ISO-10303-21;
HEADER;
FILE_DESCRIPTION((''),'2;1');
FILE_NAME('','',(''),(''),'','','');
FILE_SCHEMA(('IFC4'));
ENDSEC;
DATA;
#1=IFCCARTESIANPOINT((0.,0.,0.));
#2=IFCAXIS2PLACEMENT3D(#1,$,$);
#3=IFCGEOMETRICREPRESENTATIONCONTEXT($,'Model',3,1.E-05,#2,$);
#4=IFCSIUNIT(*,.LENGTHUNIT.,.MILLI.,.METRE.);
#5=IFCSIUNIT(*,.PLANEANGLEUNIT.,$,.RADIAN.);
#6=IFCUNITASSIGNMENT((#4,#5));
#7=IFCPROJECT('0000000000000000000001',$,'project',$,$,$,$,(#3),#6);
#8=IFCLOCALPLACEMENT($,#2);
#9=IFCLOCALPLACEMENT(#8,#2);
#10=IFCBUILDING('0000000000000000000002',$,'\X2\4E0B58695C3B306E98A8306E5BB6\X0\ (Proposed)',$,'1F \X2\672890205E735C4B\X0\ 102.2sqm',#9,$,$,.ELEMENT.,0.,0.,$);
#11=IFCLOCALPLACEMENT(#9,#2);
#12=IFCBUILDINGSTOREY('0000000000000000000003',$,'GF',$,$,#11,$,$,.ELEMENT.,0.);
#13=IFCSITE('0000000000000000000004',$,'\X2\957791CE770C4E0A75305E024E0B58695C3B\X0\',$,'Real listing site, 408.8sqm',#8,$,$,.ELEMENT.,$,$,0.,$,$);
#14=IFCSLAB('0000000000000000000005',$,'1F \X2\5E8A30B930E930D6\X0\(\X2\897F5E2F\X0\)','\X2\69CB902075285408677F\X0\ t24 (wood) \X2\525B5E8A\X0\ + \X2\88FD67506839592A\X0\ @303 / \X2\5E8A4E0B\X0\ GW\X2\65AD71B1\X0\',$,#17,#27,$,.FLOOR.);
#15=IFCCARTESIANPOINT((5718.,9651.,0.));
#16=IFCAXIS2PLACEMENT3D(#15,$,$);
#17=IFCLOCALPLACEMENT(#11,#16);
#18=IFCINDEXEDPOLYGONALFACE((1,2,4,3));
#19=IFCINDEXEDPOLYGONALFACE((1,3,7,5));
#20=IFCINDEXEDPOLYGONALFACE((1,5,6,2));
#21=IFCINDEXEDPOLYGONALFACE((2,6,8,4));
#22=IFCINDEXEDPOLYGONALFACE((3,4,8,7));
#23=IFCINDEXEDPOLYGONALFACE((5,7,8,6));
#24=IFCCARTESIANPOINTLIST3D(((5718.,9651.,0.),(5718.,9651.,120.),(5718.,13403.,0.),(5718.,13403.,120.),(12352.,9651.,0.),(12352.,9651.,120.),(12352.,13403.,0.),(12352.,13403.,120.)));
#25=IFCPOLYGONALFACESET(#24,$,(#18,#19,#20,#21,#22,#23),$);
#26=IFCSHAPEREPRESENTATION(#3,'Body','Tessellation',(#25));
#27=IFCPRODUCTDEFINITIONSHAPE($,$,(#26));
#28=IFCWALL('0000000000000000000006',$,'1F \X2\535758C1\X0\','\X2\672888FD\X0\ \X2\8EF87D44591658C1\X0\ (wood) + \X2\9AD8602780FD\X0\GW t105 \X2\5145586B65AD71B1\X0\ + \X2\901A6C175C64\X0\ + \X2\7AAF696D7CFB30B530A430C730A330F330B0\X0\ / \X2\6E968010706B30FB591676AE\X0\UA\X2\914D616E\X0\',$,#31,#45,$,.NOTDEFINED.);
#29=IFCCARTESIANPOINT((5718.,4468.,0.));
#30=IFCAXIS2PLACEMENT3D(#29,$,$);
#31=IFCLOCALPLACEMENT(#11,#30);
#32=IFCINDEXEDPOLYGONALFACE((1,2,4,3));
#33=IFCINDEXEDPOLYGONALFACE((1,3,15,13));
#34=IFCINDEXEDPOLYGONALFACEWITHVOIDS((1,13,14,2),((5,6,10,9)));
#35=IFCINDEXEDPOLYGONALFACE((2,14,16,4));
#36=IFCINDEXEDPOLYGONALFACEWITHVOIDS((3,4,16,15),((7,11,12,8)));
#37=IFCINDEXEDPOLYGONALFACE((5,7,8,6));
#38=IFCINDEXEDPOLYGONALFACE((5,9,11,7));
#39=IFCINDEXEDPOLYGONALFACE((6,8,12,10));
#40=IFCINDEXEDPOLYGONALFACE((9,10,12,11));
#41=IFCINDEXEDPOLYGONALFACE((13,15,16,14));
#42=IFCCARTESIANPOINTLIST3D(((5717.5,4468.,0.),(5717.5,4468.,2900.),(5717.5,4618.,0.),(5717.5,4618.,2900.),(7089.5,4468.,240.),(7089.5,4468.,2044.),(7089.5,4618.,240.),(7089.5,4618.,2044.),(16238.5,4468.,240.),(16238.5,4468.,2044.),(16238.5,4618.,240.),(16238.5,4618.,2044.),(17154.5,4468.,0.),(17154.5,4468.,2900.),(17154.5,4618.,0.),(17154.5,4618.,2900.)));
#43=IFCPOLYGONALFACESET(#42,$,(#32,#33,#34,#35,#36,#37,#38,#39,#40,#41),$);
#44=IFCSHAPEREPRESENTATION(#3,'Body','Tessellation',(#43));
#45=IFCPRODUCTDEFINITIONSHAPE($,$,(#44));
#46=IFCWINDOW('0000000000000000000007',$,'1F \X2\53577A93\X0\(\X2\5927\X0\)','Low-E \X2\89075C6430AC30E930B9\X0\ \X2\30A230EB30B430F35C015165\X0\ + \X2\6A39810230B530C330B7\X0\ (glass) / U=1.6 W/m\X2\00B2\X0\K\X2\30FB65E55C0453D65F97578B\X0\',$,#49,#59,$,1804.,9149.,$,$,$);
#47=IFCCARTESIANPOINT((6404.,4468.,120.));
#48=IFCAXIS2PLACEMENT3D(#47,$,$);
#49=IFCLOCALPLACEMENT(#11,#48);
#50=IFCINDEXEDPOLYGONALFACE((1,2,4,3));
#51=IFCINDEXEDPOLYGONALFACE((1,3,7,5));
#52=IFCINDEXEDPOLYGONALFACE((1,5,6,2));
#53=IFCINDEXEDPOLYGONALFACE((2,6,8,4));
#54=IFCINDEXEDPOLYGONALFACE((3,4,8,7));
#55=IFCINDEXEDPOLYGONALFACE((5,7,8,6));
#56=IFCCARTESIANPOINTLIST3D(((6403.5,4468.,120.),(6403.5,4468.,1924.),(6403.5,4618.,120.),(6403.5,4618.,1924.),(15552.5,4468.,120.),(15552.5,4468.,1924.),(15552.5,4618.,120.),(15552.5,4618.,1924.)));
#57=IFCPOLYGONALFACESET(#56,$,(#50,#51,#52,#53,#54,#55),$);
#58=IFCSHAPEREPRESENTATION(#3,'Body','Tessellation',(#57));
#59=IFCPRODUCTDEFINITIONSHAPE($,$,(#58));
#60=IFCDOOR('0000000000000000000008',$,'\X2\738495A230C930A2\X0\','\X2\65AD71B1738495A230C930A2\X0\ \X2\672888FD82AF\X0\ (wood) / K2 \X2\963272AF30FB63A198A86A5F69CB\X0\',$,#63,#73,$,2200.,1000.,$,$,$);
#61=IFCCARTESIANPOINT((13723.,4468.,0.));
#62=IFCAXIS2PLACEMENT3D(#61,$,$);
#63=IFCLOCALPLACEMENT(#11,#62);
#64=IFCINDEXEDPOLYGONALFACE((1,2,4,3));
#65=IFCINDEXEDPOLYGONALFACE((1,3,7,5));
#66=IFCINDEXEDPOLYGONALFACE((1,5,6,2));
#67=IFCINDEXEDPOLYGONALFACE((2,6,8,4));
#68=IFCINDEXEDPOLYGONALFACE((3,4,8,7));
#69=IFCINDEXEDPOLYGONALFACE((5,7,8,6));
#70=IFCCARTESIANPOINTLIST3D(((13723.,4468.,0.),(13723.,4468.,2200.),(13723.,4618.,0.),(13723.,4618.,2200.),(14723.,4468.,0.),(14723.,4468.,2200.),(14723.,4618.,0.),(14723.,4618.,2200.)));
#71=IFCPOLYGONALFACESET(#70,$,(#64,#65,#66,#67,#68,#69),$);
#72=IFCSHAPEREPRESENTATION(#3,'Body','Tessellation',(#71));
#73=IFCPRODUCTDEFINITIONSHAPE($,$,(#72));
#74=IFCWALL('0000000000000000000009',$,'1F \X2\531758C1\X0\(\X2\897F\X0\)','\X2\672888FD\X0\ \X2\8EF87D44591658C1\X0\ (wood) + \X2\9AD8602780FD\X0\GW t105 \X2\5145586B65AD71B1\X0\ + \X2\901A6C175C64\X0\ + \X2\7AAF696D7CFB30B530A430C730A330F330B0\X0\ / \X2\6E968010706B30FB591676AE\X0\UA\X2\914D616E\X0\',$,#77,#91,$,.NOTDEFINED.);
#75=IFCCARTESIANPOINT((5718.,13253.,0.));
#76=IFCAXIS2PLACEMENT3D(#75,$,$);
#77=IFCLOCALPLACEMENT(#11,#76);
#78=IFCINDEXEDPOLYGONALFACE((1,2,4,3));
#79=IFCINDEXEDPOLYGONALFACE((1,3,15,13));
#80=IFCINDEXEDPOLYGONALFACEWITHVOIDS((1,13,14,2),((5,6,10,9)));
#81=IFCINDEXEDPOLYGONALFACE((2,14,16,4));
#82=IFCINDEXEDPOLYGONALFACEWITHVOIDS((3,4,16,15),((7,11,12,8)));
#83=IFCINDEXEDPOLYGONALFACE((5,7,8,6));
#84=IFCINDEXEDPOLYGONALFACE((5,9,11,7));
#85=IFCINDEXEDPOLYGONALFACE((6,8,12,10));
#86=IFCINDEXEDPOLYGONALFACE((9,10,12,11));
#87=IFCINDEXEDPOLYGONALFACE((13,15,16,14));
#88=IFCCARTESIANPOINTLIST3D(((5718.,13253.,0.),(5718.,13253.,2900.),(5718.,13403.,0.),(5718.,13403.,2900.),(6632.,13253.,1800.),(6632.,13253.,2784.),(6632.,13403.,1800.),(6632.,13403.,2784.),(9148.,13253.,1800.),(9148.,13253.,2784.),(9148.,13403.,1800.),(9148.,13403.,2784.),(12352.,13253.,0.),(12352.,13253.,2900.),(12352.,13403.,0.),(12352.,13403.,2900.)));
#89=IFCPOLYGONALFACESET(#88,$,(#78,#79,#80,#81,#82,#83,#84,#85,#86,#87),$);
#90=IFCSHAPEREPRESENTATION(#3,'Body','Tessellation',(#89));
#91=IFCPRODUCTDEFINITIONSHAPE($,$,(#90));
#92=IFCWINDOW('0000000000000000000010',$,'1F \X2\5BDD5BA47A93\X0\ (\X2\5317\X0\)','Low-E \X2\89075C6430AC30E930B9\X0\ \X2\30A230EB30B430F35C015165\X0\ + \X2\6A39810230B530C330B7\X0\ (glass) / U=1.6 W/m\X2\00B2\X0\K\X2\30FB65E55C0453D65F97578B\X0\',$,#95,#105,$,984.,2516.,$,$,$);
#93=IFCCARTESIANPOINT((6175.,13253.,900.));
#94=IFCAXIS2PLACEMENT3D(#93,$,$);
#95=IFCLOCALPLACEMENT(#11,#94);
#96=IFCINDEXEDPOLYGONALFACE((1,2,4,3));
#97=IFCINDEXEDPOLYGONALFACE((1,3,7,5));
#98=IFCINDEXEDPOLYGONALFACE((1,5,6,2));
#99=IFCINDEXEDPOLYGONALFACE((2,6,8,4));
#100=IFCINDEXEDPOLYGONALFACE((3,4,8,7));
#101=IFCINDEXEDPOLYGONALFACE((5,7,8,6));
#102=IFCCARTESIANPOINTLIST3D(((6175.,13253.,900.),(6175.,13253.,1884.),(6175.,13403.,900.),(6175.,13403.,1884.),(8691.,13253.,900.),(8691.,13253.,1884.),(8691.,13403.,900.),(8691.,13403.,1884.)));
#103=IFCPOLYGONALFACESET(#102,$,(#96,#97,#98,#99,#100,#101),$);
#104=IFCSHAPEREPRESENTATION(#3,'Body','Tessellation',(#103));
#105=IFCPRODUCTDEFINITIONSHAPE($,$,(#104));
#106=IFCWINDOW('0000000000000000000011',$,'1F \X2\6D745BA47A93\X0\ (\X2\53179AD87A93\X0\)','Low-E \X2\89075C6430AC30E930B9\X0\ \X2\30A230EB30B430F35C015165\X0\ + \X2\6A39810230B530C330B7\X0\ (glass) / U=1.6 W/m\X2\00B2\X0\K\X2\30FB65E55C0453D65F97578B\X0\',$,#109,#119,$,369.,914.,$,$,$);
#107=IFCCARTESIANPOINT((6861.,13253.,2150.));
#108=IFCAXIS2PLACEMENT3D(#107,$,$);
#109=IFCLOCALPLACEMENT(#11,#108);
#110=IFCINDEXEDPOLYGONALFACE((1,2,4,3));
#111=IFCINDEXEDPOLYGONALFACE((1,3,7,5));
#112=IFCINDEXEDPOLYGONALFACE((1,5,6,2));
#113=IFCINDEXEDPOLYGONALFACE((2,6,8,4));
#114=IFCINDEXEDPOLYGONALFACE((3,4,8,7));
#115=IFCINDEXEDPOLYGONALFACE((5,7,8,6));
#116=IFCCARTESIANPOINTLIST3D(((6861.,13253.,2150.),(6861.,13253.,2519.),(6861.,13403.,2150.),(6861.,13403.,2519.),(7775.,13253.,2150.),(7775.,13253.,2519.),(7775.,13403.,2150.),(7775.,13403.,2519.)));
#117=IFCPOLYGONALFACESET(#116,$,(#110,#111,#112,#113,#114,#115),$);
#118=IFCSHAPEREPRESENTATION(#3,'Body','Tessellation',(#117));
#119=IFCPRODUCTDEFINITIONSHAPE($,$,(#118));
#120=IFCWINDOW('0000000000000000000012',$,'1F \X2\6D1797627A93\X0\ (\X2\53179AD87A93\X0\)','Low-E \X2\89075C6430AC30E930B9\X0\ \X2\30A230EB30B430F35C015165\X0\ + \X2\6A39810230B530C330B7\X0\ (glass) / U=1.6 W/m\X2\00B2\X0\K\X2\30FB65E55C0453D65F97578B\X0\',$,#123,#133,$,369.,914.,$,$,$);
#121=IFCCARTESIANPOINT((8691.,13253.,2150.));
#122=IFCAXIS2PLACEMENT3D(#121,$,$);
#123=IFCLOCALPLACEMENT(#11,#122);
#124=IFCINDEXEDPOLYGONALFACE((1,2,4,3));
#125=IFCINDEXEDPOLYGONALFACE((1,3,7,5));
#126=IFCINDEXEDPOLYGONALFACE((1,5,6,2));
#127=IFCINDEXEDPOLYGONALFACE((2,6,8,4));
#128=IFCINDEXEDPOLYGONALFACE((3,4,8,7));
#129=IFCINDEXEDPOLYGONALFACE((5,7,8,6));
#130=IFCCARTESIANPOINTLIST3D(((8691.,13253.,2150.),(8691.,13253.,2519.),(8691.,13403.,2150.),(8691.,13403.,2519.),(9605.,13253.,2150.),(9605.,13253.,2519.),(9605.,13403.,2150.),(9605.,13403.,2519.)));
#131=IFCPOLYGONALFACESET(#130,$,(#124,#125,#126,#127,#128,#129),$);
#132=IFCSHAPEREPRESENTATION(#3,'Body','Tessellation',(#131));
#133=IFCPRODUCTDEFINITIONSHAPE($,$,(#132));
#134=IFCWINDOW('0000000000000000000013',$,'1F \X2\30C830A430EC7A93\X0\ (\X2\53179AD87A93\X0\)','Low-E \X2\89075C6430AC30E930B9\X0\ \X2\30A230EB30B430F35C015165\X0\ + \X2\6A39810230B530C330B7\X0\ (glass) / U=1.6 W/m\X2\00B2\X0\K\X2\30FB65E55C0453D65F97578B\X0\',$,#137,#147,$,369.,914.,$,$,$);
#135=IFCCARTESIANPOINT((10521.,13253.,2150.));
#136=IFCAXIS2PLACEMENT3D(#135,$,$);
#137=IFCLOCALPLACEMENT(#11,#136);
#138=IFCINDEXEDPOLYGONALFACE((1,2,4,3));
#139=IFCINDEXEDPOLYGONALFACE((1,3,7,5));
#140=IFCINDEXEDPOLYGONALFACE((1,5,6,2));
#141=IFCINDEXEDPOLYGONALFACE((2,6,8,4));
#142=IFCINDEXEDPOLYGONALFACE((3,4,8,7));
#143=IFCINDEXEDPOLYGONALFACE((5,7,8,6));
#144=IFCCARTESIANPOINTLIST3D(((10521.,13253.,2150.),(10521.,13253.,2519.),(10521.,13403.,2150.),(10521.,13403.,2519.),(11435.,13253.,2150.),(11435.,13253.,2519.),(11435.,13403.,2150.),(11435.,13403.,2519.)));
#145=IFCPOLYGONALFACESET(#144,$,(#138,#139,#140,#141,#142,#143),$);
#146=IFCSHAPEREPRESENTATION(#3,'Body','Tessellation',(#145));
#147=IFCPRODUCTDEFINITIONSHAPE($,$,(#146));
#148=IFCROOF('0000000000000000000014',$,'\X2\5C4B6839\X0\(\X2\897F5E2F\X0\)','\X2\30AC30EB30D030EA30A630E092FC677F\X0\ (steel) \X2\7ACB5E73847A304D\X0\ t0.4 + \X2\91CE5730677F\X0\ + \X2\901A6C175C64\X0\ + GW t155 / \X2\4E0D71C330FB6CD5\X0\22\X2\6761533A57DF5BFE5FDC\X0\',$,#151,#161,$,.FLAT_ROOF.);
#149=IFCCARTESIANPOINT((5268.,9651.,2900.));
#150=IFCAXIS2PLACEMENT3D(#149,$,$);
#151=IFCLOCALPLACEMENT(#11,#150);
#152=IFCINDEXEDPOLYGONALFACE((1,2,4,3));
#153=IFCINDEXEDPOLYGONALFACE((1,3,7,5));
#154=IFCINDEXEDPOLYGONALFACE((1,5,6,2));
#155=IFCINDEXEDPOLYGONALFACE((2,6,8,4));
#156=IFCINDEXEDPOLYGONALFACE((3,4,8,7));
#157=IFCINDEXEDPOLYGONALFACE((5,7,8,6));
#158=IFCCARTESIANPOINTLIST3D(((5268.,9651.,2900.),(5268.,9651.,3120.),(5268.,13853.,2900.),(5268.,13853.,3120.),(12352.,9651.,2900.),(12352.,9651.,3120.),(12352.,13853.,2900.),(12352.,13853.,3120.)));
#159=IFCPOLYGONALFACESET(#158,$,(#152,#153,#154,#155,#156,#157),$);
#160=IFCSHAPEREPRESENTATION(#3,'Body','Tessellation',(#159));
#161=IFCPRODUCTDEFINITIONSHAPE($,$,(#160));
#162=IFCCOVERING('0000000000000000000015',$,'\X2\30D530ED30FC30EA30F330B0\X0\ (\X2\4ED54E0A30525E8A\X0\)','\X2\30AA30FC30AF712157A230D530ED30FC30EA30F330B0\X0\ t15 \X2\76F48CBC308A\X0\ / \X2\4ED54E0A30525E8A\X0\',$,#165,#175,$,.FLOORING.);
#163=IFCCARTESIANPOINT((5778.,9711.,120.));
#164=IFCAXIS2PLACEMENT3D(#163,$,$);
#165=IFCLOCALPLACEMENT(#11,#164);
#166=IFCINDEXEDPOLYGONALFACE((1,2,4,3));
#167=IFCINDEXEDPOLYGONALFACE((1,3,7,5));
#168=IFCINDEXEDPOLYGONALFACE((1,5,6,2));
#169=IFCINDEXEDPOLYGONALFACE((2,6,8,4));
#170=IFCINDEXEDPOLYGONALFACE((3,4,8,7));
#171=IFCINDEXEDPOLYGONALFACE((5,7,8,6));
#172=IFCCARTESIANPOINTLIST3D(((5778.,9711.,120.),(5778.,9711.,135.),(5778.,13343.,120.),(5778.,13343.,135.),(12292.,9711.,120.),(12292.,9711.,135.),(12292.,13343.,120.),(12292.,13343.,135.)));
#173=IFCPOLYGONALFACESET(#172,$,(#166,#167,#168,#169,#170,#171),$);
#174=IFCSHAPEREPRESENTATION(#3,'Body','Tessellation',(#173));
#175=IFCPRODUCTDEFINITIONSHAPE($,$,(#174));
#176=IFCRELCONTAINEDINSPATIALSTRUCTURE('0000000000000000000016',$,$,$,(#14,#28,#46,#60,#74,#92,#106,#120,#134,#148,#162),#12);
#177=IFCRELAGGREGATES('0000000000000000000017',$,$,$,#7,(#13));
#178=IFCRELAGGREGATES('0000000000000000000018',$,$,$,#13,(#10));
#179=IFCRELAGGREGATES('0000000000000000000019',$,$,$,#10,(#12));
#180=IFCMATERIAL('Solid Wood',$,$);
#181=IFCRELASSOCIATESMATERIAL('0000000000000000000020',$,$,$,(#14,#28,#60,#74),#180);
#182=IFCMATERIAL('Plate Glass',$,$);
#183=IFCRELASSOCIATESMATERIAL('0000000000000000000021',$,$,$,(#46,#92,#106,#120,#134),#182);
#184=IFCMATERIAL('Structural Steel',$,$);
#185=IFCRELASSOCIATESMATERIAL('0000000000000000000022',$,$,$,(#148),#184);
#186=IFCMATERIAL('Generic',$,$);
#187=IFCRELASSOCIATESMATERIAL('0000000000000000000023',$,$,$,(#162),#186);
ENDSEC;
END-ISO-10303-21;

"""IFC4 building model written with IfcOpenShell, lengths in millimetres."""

from ifc_helpers import new_model, si_unit, frame, frame_2d, origin, place, context, project, spatial, rectangle, extrude, material, element, fill, save


model = new_model("IFC4")

# Units and contexts
model_context = context("Model", 3, precision=1e-05, world=origin())
ifc_project = project(units=[si_unit("LENGTHUNIT", "METRE", prefix="MILLI"), si_unit("PLANEANGLEUNIT", "RADIAN")], contexts=[model_context])

# Site, building, storey
site_placement = place(None, origin())
site = spatial("IfcSite", under=ifc_project, at=site_placement, Name="長野県上田市下塩尻", ObjectType="Real listing site, 408.8sqm", CompositionType="ELEMENT", RefElevation=0.0)
building_placement = place(site_placement, origin())
building = spatial("IfcBuilding", under=site, at=building_placement, Name="下塩尻の風の家 (Proposed)", ObjectType="1F 木造平屋 102.2sqm", CompositionType="ELEMENT", ElevationOfRefHeight=0.0, ElevationOfTerrain=0.0)
storey_placement = place(building_placement, origin())
storey = spatial("IfcBuildingStorey", under=building, at=storey_placement, Name="GF", CompositionType="ELEMENT", Elevation=0.0)

# Slab
ifc_material_1 = material(Name="Solid Wood")
slab_1_placement = place(storey_placement, frame((5718.0, 9651.0, 0.0)))
element("IfcSlab", 1, at=slab_1_placement, inside=storey, material=ifc_material_1, Name="1F 床スラブ(西帯)", Description="構造用合板 t24 (wood) 剛床 + 製材根太 @303 / 床下 GW断熱", PredefinedType="FLOOR", context=model_context, shape_type="SweptSolid", body=[
    extrude(rectangle(XDim=6634.0, YDim=3752.0, at=frame_2d((3317.0, 1876.0))), frame((5718.0, 9651.0, 0.0)), (0.0, 0.0, 1.0), 120.0),
])

# Wall, openings, window, door
wall_1_placement = place(storey_placement, frame((5718.0, 4468.0, 0.0)))
wall_1 = element("IfcWall", 2, at=wall_1_placement, inside=storey, material=ifc_material_1, Name="1F 南壁", Description="木製 軸組外壁 (wood) + 高性能GW t105 充填断熱 + 通気層 + 窯業系サイディング / 準耐火・外皮UA配慮", PredefinedType="NOTDEFINED", context=model_context, shape_type="SweptSolid", body=[
    extrude(rectangle(XDim=11437.0, YDim=150.0, at=frame_2d((5718.0, 75.0))), frame((5718.0, 4468.0, 0.0)), (0.0, 0.0, 1.0), 2900.0),
])
opening_1_placement = place(storey_placement, frame((6404.0, 4468.0, 120.0)))
opening_1 = element("IfcOpeningElement", 3, at=opening_1_placement, cuts=wall_1, PredefinedType="NOTDEFINED", context=model_context, shape_type="SweptSolid", body=[
    extrude(rectangle(XDim=9149.0, YDim=150.0, at=frame_2d((4574.0, 75.0))), frame((6404.0, 4468.0, 120.0)), (0.0, 0.0, 1.0), 1804.0),
])
opening_2_placement = place(storey_placement, frame((13723.0, 4468.0, 0.0)))
opening_2 = element("IfcOpeningElement", 4, at=opening_2_placement, cuts=wall_1, PredefinedType="NOTDEFINED", context=model_context, shape_type="SweptSolid", body=[
    extrude(rectangle(XDim=1000.0, YDim=150.0, at=frame_2d((500.0, 75.0))), frame((13723.0, 4468.0, 0.0)), (0.0, 0.0, 1.0), 2200.0),
])
ifc_material_2 = material(Name="Plate Glass")
window_1_placement = place(storey_placement, frame((6404.0, 4468.0, 120.0)))
window_1 = element("IfcWindow", 5, at=window_1_placement, inside=storey, material=ifc_material_2, Name="1F 南窓(大)", Description="Low-E 複層ガラス アルゴン封入 + 樹脂サッシ (glass) / U=1.6 W/m²K・日射取得型", OverallHeight=1804.0, OverallWidth=9149.0, context=model_context, shape_type="SweptSolid", body=[
    extrude(rectangle(XDim=9149.0, YDim=150.0, at=frame_2d((4574.0, 75.0))), frame((6404.0, 4468.0, 120.0)), (0.0, 0.0, 1.0), 1804.0),
])
fill(opening_1, window_1)
door_1_placement = place(storey_placement, frame((13723.0, 4468.0, 0.0)))
door_1 = element("IfcDoor", 6, at=door_1_placement, inside=storey, material=ifc_material_1, Name="玄関ドア", Description="断熱玄関ドア 木製芯 (wood) / K2 防犯・採風機構", OverallHeight=2200.0, OverallWidth=1000.0, context=model_context, shape_type="SweptSolid", body=[
    extrude(rectangle(XDim=1000.0, YDim=150.0, at=frame_2d((500.0, 75.0))), frame((13723.0, 4468.0, 0.0)), (0.0, 0.0, 1.0), 2200.0),
])
fill(opening_2, door_1)

# Wall, openings, windows
wall_2_placement = place(storey_placement, frame((5718.0, 13253.0, 0.0)))
wall_2 = element("IfcWall", 7, at=wall_2_placement, inside=storey, material=ifc_material_1, Name="1F 北壁(西)", Description="木製 軸組外壁 (wood) + 高性能GW t105 充填断熱 + 通気層 + 窯業系サイディング / 準耐火・外皮UA配慮", PredefinedType="NOTDEFINED", context=model_context, shape_type="SweptSolid", body=[
    extrude(rectangle(XDim=6634.0, YDim=150.0, at=frame_2d((3317.0, 75.0))), frame((5718.0, 13253.0, 0.0)), (0.0, 0.0, 1.0), 2900.0),
])
opening_3_placement = place(storey_placement, frame((6175.0, 13253.0, 900.0)))
opening_3 = element("IfcOpeningElement", 8, at=opening_3_placement, cuts=wall_2, PredefinedType="NOTDEFINED", context=model_context, shape_type="SweptSolid", body=[
    extrude(rectangle(XDim=2516.0, YDim=150.0, at=frame_2d((1258.0, 75.0))), frame((6175.0, 13253.0, 900.0)), (0.0, 0.0, 1.0), 984.0),
])
opening_4_placement = place(storey_placement, frame((6861.0, 13253.0, 2150.0)))
opening_4 = element("IfcOpeningElement", 9, at=opening_4_placement, cuts=wall_2, PredefinedType="NOTDEFINED", context=model_context, shape_type="SweptSolid", body=[
    extrude(rectangle(XDim=914.0, YDim=150.0, at=frame_2d((457.0, 75.0))), frame((6861.0, 13253.0, 2150.0)), (0.0, 0.0, 1.0), 369.0),
])
opening_5_placement = place(storey_placement, frame((8691.0, 13253.0, 2150.0)))
opening_5 = element("IfcOpeningElement", 10, at=opening_5_placement, cuts=wall_2, PredefinedType="NOTDEFINED", context=model_context, shape_type="SweptSolid", body=[
    extrude(rectangle(XDim=914.0, YDim=150.0, at=frame_2d((457.0, 75.0))), frame((8691.0, 13253.0, 2150.0)), (0.0, 0.0, 1.0), 369.0),
])
opening_6_placement = place(storey_placement, frame((10521.0, 13253.0, 2150.0)))
opening_6 = element("IfcOpeningElement", 11, at=opening_6_placement, cuts=wall_2, PredefinedType="NOTDEFINED", context=model_context, shape_type="SweptSolid", body=[
    extrude(rectangle(XDim=914.0, YDim=150.0, at=frame_2d((457.0, 75.0))), frame((10521.0, 13253.0, 2150.0)), (0.0, 0.0, 1.0), 369.0),
])
window_2_placement = place(storey_placement, frame((6175.0, 13253.0, 900.0)))
window_2 = element("IfcWindow", 12, at=window_2_placement, inside=storey, material=ifc_material_2, Name="1F 寝室窓 (北)", Description="Low-E 複層ガラス アルゴン封入 + 樹脂サッシ (glass) / U=1.6 W/m²K・日射取得型", OverallHeight=984.0, OverallWidth=2516.0, context=model_context, shape_type="SweptSolid", body=[
    extrude(rectangle(XDim=2516.0, YDim=150.0, at=frame_2d((1258.0, 75.0))), frame((6175.0, 13253.0, 900.0)), (0.0, 0.0, 1.0), 984.0),
])
fill(opening_3, window_2)
window_3_placement = place(storey_placement, frame((6861.0, 13253.0, 2150.0)))
window_3 = element("IfcWindow", 13, at=window_3_placement, inside=storey, material=ifc_material_2, Name="1F 浴室窓 (北高窓)", Description="Low-E 複層ガラス アルゴン封入 + 樹脂サッシ (glass) / U=1.6 W/m²K・日射取得型", OverallHeight=369.0, OverallWidth=914.0, context=model_context, shape_type="SweptSolid", body=[
    extrude(rectangle(XDim=914.0, YDim=150.0, at=frame_2d((457.0, 75.0))), frame((6861.0, 13253.0, 2150.0)), (0.0, 0.0, 1.0), 369.0),
])
fill(opening_4, window_3)
window_4_placement = place(storey_placement, frame((8691.0, 13253.0, 2150.0)))
window_4 = element("IfcWindow", 14, at=window_4_placement, inside=storey, material=ifc_material_2, Name="1F 洗面窓 (北高窓)", Description="Low-E 複層ガラス アルゴン封入 + 樹脂サッシ (glass) / U=1.6 W/m²K・日射取得型", OverallHeight=369.0, OverallWidth=914.0, context=model_context, shape_type="SweptSolid", body=[
    extrude(rectangle(XDim=914.0, YDim=150.0, at=frame_2d((457.0, 75.0))), frame((8691.0, 13253.0, 2150.0)), (0.0, 0.0, 1.0), 369.0),
])
fill(opening_5, window_4)
window_5_placement = place(storey_placement, frame((10521.0, 13253.0, 2150.0)))
window_5 = element("IfcWindow", 15, at=window_5_placement, inside=storey, material=ifc_material_2, Name="1F トイレ窓 (北高窓)", Description="Low-E 複層ガラス アルゴン封入 + 樹脂サッシ (glass) / U=1.6 W/m²K・日射取得型", OverallHeight=369.0, OverallWidth=914.0, context=model_context, shape_type="SweptSolid", body=[
    extrude(rectangle(XDim=914.0, YDim=150.0, at=frame_2d((457.0, 75.0))), frame((10521.0, 13253.0, 2150.0)), (0.0, 0.0, 1.0), 369.0),
])
fill(opening_6, window_5)

# Roof
ifc_material_3 = material(Name="Structural Steel")
roof_1_placement = place(storey_placement, frame((5268.0, 9651.0, 2900.0)))
element("IfcRoof", 16, at=roof_1_placement, inside=storey, material=ifc_material_3, Name="屋根(西帯)", Description="ガルバリウム鋼板 (steel) 立平葺き t0.4 + 野地板 + 通気層 + GW t155 / 不燃・法22条区域対応", PredefinedType="FLAT_ROOF", context=model_context, shape_type="SweptSolid", body=[
    extrude(rectangle(XDim=7084.0, YDim=4202.0, at=frame_2d((3542.0, 2101.0))), frame((5268.0, 9651.0, 2900.0)), (0.0, 0.0, 1.0), 220.0),
])

# Covering
ifc_material_4 = material(Name="Generic")
covering_1_placement = place(storey_placement, frame((5778.0, 9711.0, 120.0)))
element("IfcCovering", 17, at=covering_1_placement, inside=storey, material=ifc_material_4, Name="フローリング (仕上げ床)", Description="オーク無垢フローリング t15 直貼り / 仕上げ床", PredefinedType="FLOORING", context=model_context, shape_type="SweptSolid", body=[
    extrude(rectangle(XDim=6514.0, YDim=3632.0, at=frame_2d((3257.0, 1816.0))), frame((5778.0, 9711.0, 120.0)), (0.0, 0.0, 1.0), 15.0),
])

save(model, "model.ifc")
